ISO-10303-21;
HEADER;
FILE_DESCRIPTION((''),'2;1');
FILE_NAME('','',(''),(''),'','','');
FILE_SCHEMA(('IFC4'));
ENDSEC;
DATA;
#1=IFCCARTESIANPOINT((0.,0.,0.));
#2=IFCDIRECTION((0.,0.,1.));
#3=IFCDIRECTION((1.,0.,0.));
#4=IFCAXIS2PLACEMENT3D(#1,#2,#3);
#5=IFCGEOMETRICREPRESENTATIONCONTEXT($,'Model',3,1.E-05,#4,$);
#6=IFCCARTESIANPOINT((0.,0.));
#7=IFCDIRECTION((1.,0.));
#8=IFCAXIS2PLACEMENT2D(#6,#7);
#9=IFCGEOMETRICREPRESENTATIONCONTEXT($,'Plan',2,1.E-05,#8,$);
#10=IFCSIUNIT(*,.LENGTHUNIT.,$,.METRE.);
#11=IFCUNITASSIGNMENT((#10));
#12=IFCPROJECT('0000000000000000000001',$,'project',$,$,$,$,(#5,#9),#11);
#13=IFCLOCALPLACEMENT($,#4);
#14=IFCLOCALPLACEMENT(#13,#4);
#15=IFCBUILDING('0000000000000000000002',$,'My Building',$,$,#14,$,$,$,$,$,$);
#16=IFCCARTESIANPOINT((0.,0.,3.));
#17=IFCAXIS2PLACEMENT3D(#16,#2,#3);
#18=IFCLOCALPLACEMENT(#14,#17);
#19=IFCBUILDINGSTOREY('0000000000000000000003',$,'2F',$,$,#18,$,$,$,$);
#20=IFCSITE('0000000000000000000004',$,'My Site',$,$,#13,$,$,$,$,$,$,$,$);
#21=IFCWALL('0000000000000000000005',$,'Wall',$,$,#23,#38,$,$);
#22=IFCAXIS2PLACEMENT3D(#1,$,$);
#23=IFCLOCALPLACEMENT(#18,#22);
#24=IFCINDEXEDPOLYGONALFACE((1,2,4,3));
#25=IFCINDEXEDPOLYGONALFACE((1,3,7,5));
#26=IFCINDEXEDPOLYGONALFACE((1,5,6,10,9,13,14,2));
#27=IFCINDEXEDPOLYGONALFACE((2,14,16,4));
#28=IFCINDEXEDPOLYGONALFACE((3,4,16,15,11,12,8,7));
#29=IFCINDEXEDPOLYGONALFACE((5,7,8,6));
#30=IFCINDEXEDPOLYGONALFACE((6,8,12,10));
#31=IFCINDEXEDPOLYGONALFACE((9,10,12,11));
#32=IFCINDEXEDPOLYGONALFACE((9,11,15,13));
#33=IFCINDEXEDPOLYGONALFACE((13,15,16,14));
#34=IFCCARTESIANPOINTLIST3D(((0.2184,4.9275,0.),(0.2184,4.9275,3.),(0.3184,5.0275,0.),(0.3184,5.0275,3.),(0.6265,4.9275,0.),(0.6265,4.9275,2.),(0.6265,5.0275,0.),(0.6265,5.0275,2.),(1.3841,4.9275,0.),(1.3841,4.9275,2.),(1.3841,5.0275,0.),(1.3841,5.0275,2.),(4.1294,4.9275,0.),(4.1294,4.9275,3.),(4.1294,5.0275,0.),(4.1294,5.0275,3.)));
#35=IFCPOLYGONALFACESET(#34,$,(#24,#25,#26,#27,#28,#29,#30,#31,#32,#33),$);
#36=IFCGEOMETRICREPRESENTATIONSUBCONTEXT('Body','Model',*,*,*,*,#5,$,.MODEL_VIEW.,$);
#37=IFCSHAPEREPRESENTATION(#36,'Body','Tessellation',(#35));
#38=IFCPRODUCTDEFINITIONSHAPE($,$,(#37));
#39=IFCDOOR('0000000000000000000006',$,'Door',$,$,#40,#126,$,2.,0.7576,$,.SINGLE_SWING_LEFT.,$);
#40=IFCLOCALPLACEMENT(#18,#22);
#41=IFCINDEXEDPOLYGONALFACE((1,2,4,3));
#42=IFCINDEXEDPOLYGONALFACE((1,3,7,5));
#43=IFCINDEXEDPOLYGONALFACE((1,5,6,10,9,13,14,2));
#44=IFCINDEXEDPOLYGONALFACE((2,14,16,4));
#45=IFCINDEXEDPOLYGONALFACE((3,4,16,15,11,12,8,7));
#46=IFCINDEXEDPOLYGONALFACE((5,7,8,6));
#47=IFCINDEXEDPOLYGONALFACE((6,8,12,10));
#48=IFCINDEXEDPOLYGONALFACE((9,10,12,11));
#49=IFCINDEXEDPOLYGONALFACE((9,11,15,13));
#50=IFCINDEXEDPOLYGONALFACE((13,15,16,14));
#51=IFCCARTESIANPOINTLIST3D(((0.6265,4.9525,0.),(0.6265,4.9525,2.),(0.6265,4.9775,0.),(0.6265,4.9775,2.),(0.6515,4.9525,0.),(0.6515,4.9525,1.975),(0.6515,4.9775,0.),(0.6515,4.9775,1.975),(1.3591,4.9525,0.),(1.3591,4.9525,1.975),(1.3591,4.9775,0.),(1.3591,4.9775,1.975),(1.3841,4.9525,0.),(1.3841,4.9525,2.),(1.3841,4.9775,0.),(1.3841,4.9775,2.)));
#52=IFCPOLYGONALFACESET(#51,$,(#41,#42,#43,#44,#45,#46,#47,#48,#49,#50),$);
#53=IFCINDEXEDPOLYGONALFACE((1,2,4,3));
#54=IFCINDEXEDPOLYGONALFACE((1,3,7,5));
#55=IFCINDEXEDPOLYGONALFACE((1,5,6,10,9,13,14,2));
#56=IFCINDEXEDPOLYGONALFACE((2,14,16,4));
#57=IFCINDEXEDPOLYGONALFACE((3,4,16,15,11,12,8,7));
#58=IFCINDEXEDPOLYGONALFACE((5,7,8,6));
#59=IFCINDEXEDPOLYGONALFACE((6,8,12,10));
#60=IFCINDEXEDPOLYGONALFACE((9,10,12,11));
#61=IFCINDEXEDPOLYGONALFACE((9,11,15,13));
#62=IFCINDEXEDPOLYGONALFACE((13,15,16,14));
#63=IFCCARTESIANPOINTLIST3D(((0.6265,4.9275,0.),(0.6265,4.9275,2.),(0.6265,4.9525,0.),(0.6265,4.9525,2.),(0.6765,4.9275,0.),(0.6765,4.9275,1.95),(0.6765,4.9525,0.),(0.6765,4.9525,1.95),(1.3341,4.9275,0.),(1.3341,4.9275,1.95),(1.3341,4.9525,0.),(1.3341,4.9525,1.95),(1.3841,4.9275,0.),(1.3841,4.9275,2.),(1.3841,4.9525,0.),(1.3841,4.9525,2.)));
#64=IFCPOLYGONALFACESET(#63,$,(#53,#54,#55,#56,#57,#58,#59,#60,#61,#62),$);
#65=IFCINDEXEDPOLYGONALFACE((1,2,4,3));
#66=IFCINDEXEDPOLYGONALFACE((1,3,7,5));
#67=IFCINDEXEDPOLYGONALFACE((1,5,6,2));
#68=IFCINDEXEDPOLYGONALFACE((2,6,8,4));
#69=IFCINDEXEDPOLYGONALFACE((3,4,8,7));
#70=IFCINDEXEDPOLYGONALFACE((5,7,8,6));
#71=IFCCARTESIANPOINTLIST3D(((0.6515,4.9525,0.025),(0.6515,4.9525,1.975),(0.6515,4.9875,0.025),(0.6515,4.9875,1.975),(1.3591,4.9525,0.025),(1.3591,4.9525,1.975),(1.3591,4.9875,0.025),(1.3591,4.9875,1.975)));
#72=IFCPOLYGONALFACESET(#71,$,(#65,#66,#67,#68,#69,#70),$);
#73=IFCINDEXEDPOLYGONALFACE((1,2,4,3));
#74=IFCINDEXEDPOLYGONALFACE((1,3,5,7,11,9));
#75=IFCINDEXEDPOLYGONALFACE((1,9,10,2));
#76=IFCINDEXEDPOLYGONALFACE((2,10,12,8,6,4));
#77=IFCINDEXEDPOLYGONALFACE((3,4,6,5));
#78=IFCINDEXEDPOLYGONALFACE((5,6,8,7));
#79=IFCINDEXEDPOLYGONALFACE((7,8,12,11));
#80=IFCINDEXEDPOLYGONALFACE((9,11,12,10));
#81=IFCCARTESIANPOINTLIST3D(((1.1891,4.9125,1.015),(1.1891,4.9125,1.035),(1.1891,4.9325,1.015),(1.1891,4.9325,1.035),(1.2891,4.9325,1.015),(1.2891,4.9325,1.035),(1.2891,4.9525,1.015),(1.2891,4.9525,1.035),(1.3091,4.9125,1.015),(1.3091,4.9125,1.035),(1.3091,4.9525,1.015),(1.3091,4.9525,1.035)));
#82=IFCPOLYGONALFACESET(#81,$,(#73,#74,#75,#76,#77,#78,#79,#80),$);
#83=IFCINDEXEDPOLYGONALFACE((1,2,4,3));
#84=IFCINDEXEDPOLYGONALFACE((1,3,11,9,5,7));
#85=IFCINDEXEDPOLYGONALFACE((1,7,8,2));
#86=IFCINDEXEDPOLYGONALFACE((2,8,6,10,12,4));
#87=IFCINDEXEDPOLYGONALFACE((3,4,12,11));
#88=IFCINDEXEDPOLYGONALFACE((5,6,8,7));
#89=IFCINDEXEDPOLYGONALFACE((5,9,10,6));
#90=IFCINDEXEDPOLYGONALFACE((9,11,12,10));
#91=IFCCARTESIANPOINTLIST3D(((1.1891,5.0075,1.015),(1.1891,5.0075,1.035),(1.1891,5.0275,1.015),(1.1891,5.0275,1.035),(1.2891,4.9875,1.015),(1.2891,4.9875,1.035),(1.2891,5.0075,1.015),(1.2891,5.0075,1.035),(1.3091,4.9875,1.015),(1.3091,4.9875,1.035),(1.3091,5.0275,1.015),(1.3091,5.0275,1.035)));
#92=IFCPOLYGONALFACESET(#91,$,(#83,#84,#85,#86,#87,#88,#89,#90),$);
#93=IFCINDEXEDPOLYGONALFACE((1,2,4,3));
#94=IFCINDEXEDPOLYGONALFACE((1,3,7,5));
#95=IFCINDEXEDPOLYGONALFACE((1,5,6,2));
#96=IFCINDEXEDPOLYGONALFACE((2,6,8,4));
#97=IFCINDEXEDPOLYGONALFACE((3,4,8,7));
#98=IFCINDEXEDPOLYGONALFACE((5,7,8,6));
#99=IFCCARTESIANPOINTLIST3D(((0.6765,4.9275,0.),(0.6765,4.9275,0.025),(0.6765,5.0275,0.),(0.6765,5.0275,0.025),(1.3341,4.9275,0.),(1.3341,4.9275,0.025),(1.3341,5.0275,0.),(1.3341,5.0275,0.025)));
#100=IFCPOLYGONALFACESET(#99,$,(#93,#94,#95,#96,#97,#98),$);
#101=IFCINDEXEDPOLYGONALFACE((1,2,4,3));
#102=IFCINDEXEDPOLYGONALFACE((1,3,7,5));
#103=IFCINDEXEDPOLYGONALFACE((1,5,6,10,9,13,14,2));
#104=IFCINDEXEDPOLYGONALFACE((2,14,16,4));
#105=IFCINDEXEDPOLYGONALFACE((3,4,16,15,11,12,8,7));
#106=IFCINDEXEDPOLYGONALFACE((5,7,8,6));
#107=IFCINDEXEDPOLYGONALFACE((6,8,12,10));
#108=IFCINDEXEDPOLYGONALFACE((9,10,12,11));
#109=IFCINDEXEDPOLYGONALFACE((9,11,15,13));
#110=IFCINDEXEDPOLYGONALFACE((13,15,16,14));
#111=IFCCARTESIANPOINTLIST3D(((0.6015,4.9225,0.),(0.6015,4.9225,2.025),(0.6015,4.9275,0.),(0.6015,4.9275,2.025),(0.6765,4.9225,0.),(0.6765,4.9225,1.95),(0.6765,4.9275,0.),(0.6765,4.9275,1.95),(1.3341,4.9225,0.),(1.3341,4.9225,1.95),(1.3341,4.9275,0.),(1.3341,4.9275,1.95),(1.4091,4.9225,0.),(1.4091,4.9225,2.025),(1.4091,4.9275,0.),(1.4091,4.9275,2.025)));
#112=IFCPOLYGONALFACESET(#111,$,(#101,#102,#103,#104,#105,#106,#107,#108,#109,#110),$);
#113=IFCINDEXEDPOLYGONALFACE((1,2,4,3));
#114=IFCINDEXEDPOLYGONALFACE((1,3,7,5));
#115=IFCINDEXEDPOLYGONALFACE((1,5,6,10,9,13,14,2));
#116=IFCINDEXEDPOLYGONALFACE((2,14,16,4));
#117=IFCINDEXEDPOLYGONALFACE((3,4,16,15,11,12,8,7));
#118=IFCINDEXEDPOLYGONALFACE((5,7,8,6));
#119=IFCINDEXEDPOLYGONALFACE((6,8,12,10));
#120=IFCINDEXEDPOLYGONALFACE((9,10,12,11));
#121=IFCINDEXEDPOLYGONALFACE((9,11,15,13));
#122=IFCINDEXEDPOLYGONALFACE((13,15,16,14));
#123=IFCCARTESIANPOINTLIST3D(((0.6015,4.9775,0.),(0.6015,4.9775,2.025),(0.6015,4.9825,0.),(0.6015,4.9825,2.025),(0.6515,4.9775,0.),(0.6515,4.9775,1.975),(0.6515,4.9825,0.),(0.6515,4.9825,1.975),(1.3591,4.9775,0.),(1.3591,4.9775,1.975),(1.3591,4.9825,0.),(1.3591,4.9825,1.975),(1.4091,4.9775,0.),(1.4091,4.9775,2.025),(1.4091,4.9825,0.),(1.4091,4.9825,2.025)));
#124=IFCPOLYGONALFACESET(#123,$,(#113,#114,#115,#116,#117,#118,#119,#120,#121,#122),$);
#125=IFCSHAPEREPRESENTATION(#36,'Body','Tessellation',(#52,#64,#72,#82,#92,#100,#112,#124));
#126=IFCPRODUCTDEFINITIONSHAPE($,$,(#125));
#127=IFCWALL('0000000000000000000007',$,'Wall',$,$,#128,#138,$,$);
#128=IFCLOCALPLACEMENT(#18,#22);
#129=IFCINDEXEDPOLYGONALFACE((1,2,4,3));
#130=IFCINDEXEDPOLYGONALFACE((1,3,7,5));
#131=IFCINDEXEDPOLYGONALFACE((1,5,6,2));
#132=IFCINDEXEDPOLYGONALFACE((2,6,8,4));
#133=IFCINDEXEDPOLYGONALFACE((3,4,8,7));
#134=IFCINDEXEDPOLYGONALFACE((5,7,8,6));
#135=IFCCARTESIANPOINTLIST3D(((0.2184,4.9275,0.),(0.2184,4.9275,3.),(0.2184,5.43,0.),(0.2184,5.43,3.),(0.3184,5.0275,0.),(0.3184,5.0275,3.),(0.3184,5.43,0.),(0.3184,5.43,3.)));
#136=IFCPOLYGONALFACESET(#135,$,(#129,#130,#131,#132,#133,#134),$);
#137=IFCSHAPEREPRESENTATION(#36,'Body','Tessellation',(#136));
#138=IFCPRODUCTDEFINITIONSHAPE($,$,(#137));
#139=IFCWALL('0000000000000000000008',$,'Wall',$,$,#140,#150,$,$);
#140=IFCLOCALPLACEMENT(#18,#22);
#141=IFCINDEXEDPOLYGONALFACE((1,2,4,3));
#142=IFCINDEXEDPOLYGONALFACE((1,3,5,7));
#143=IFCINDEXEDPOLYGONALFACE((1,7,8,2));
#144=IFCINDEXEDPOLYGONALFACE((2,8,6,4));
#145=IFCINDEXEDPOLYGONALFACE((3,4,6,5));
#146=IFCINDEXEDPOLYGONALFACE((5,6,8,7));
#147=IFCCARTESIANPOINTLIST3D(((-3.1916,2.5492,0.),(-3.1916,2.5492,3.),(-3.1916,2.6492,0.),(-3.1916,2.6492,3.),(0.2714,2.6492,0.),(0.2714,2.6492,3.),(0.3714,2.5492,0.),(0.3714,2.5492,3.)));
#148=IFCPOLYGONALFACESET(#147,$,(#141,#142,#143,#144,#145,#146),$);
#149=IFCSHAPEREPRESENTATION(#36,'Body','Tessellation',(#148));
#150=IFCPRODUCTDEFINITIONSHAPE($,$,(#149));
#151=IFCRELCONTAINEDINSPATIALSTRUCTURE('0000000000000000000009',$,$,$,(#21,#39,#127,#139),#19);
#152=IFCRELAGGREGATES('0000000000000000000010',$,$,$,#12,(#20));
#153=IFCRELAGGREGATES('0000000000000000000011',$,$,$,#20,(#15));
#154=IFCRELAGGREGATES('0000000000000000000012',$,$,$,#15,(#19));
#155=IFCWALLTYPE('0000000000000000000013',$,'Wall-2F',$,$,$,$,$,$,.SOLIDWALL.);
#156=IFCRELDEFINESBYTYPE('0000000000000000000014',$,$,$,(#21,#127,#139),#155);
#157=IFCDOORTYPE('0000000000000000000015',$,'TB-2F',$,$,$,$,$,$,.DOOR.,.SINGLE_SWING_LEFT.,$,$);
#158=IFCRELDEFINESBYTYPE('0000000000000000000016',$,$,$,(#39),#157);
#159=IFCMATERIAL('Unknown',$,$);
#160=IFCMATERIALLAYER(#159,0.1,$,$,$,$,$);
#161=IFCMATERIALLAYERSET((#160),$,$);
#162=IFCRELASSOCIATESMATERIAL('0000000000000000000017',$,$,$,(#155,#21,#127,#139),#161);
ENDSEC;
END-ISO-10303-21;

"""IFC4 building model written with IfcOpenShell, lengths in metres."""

from ifc_helpers import new_model, entity, si_unit, frame, origin_with_axes, origin_2d_with_axis, place, context, subcontext, project, spatial, line, indexed_curve, outline, extrude, shape, source, transform, mapped, material, layer, layer_set, layer_usage, type_object, type_shapes, element, fill, save


model = new_model("IFC4")

# Units and contexts
model_context = context("Model", 3, precision=1e-05, world=origin_with_axes())
plan_context = context("Plan", 2, precision=1e-05, world=origin_2d_with_axis())
body_context_1 = subcontext(model_context, "Body", "Model", "MODEL_VIEW")
body_context_2 = subcontext(plan_context, "Body", "Plan", "PLAN_VIEW")
ifc_project = project(units=[si_unit("LENGTHUNIT", "METRE")], contexts=[model_context, plan_context])

# Site, building, storey
site_placement = place(None, origin_with_axes())
site = spatial("IfcSite", under=ifc_project, at=site_placement, Name="My Site")
building_placement = place(site_placement, origin_with_axes())
building = spatial("IfcBuilding", under=site, at=building_placement, Name="My Building")
storey_placement = place(building_placement, frame((0.0, 0.0, 3.0), z_axis=(0.0, 0.0, 1.0), x_axis=(1.0, 0.0, 0.0)))
storey = spatial("IfcBuildingStorey", under=building, at=storey_placement, Name="2F")

# Shared definitions
ifc_material = material(Name="Unknown")
ifc_layer_1 = layer(ifc_material, 0.1)
ifc_layer_set_1 = layer_set([ifc_layer_1])
wall_type_1 = type_object("IfcWallType", Name="Wall-2F", PredefinedType="SOLIDWALL", material=ifc_layer_set_1)

# Wall, opening, door
ifc_layer_usage_1 = layer_usage(ifc_layer_set_1, "AXIS2", "POSITIVE", 0.0)
wall_1_placement = place(storey_placement, frame((4.2294, 5.0275, 0.0), z_axis=(0.0, 0.0, 1.0), x_axis=(-1.0, 0.0, 0.0)))
wall_1 = element("IfcWall", 1, at=wall_1_placement, inside=storey, type_object=wall_type_1, material=ifc_layer_usage_1, Name="Wall", context=body_context_1, shape_type="SweptSolid", body=[
    extrude(outline(indexed_curve([(0.1, 0.0), (0.1, 0.1), (4.0111, 0.1), (3.9111, 0.0)], segments=[line(1, 2, 3, 4, 1)])), origin_with_axes(), (0.0, 0.0, 1.0), 3.0),
])
shared_shape_1 = source(origin_with_axes(), body_context_1, "Body", "SweptSolid", [
    extrude(outline(indexed_curve([(0.0, 0.0), (0.7576, 0.0), (0.7576, 2.0), (0.0, 2.0)], segments=[line(1, 2, 3, 4, 1)])), frame((0.0, -0.6, 0.0), z_axis=(0.0, -1.0, 0.0), x_axis=(1.0, 0.0, 0.0)), (0.0, 0.0, -1.0), 1.2),
])
opening_1_placement = place(wall_1_placement, frame((3.6029, 0.1, 0.0), z_axis=(0.0, 0.0, 1.0), x_axis=(-1.0, 0.0, 0.0)))
opening_1 = element("IfcOpeningElement", 2, at=opening_1_placement, cuts=wall_1, PredefinedType="OPENING", context=body_context_1, shape_type="MappedRepresentation", body=[
    mapped(shared_shape_1, transform((0.0, 0.0, 0.0), x_axis=(1.0, 0.0, 0.0), y_axis=(0.0, 1.0, 0.0), z_axis=(0.0, 0.0, 1.0), scale=1.0)),
])
door_type_1 = type_object("IfcDoorType", Name="TB-2F", OperationType="SINGLE_SWING_LEFT", PredefinedType="DOOR")
shared_shape_2 = source(origin_with_axes(), body_context_1, "Body", "SweptSolid", [
    extrude(outline(indexed_curve([(0.0, 0.0), (0.0, 2.0), (0.7576, 2.0), (0.7576, 0.0), (0.7326, 0.0), (0.7326, 1.975), (0.025, 1.975), (0.025, 0.0)], segments=[line(1, 2, 3, 4, 5, 6, 7, 8, 1)])), frame((0.0, 0.025, 0.0), z_axis=(0.0, -1.0, 0.0), x_axis=(1.0, 0.0, 0.0)), (0.0, 0.0, -1.0), 0.025),
    extrude(outline(indexed_curve([(0.0, 0.0), (0.0, 2.0), (0.7576, 2.0), (0.7576, 0.0), (0.7076, 0.0), (0.7076, 1.95), (0.05, 1.95), (0.05, 0.0)], segments=[line(1, 2, 3, 4, 5, 6, 7, 8, 1)])), frame((0.0, 0.0, 0.0), z_axis=(0.0, -1.0, 0.0), x_axis=(1.0, 0.0, 0.0)), (0.0, 0.0, -1.0), 0.025),
    extrude(outline(indexed_curve([(0.0, 0.0), (0.7076, 0.0), (0.7076, 0.035), (0.0, 0.035)], segments=[line(1, 2, 3, 4, 1)])), frame((0.025, 0.025, 0.025), z_axis=(0.0, 0.0, 1.0), x_axis=(1.0, 0.0, 0.0)), (0.0, 0.0, 1.0), 1.95),
    extrude(outline(indexed_curve([(0.0, 0.0), (0.0, -0.04), (-0.12, -0.04), (-0.12, -0.02), (-0.02, -0.02), (-0.02, 0.0)], segments=[line(1, 2, 3, 4, 5, 6, 1)])), frame((0.6826, 0.025, 1.015), z_axis=(0.0, 0.0, 1.0), x_axis=(1.0, 0.0, 0.0)), (0.0, 0.0, 1.0), 0.02),
    extrude(outline(indexed_curve([(0.0, 0.0), (0.0, 0.04), (-0.12, 0.04), (-0.12, 0.02), (-0.02, 0.02), (-0.02, 0.0)], segments=[line(1, 2, 3, 4, 5, 6, 1)])), frame((0.6826, 0.06, 1.015), z_axis=(0.0, 0.0, 1.0), x_axis=(1.0, 0.0, 0.0)), (0.0, 0.0, 1.0), 0.02),
    extrude(outline(indexed_curve([(0.0, 0.0), (0.6576, 0.0), (0.6576, 0.1), (0.0, 0.1)], segments=[line(1, 2, 3, 4, 1)])), frame((0.05, 0.0, 0.0), z_axis=(0.0, 0.0, 1.0), x_axis=(1.0, 0.0, 0.0)), (0.0, 0.0, 1.0), 0.025),
    extrude(outline(indexed_curve([(0.0, 0.0), (0.0, 2.025), (0.8076, 2.025), (0.8076, 0.0), (0.7326, 0.0), (0.7326, 1.95), (0.075, 1.95), (0.075, 0.0)], segments=[line(1, 2, 3, 4, 5, 6, 7, 8, 1)])), frame((-0.025, -0.005, 0.0), z_axis=(0.0, -1.0, 0.0), x_axis=(1.0, 0.0, 0.0)), (0.0, 0.0, -1.0), 0.005),
    extrude(outline(indexed_curve([(0.0, 0.0), (0.0, 2.025), (0.8076, 2.025), (0.8076, 0.0), (0.7576, 0.0), (0.7576, 1.975), (0.05, 1.975), (0.05, 0.0)], segments=[line(1, 2, 3, 4, 5, 6, 7, 8, 1)])), frame((-0.025, 0.05, 0.0), z_axis=(0.0, -1.0, 0.0), x_axis=(1.0, 0.0, 0.0)), (0.0, 0.0, -1.0), 0.005),
])
shared_shape_3 = source(origin_with_axes(), body_context_2, "Body", "Curve2D", [
    entity("IfcIndexedPolyCurve", entity("IfcCartesianPointList2D", [[0.0, 0.0], [0.0, 0.05], [0.025, 0.05], [0.025, 0.025], [0.05, 0.025], [0.05, 0.0]]), [entity("IfcLineIndex", [1, 2, 3, 4, 5, 6, 1])]),
    entity("IfcIndexedPolyCurve", entity("IfcCartesianPointList2D", [[0.7576, 0.0], [0.7576, 0.05], [0.7326, 0.05], [0.7326, 0.025], [0.7076, 0.025], [0.7076, 0.0]]), [entity("IfcLineIndex", [1, 2, 3, 4, 5, 6, 1])]),
    entity("IfcTrimmedCurve", entity("IfcEllipse", entity("IfcAxis2Placement2D", entity("IfcCartesianPoint", [0.06, 0.05]), entity("IfcDirection", [1.0, 0.0])), 0.6726, 0.7076), [entity("IfcCartesianPoint", [0.7326, 0.05])], [entity("IfcCartesianPoint", [0.06, 0.7576])], True, "CARTESIAN"),
    entity("IfcIndexedPolyCurve", entity("IfcCartesianPointList2D", [[0.025, 0.05], [0.06, 0.05], [0.06, 0.7576], [0.025, 0.7576]]), [entity("IfcLineIndex", [1, 2, 3, 4, 1])]),
])
type_shapes(door_type_1, [shared_shape_2, shared_shape_3])
door_1_placement = place(opening_1_placement, frame((0.0, 0.0, 0.0), z_axis=(0.0, 0.0, 1.0), x_axis=(1.0, 0.0, 0.0)))
door_1 = element("IfcDoor", 3, at=door_1_placement, inside=storey, type_object=door_type_1, Name="Door", OperationType="SINGLE_SWING_LEFT", OverallHeight=2.0, OverallWidth=0.7576, shapes=[
    shape(body_context_1, "Body", "MappedRepresentation", [mapped(shared_shape_2, transform((0.0, 0.0, 0.0), x_axis=(1.0, 0.0, 0.0), y_axis=(0.0, 1.0, 0.0), z_axis=(0.0, 0.0, 1.0), scale=1.0))]),
    shape(body_context_2, "Body", "MappedRepresentation", [mapped(shared_shape_3, transform((0.0, 0.0, 0.0), x_axis=(1.0, 0.0, 0.0), y_axis=(0.0, 1.0, 0.0), z_axis=(0.0, 0.0, 1.0), scale=1.0))]),
])
fill(opening_1, door_1)

# Walls
ifc_layer_usage_2 = layer_usage(ifc_layer_set_1, "AXIS2", "NEGATIVE", 0.0)
wall_2_placement = place(storey_placement, frame((0.3184, 5.43, 0.0), z_axis=(0.0, 0.0, 1.0), x_axis=(0.0, -1.0, 0.0)))
element("IfcWall", 4, at=wall_2_placement, inside=storey, type_object=wall_type_1, material=ifc_layer_usage_2, Name="Wall", context=body_context_1, shape_type="SweptSolid", body=[
    extrude(outline(indexed_curve([(0.0, -0.1), (0.0, 0.0), (0.4025, 0.0), (0.5025, -0.1)], segments=[line(1, 2, 3, 4, 1)])), origin_with_axes(), (0.0, 0.0, 1.0), 3.0),
])
ifc_layer_usage_3 = layer_usage(ifc_layer_set_1, "AXIS2", "POSITIVE", 0.0)
wall_3_placement = place(storey_placement, frame((-3.1916, 2.5492, 0.0), z_axis=(0.0, 0.0, 1.0), x_axis=(1.0, 0.0, 0.0)))
element("IfcWall", 5, at=wall_3_placement, inside=storey, type_object=wall_type_1, material=ifc_layer_usage_3, Name="Wall", context=body_context_1, shape_type="SweptSolid", body=[
    extrude(outline(indexed_curve([(0.0, 0.0), (0.0, 0.1), (3.463, 0.1), (3.563, 0.0)], segments=[line(1, 2, 3, 4, 1)])), origin_with_axes(), (0.0, 0.0, 1.0), 3.0),
])

save(model, "model.ifc")
